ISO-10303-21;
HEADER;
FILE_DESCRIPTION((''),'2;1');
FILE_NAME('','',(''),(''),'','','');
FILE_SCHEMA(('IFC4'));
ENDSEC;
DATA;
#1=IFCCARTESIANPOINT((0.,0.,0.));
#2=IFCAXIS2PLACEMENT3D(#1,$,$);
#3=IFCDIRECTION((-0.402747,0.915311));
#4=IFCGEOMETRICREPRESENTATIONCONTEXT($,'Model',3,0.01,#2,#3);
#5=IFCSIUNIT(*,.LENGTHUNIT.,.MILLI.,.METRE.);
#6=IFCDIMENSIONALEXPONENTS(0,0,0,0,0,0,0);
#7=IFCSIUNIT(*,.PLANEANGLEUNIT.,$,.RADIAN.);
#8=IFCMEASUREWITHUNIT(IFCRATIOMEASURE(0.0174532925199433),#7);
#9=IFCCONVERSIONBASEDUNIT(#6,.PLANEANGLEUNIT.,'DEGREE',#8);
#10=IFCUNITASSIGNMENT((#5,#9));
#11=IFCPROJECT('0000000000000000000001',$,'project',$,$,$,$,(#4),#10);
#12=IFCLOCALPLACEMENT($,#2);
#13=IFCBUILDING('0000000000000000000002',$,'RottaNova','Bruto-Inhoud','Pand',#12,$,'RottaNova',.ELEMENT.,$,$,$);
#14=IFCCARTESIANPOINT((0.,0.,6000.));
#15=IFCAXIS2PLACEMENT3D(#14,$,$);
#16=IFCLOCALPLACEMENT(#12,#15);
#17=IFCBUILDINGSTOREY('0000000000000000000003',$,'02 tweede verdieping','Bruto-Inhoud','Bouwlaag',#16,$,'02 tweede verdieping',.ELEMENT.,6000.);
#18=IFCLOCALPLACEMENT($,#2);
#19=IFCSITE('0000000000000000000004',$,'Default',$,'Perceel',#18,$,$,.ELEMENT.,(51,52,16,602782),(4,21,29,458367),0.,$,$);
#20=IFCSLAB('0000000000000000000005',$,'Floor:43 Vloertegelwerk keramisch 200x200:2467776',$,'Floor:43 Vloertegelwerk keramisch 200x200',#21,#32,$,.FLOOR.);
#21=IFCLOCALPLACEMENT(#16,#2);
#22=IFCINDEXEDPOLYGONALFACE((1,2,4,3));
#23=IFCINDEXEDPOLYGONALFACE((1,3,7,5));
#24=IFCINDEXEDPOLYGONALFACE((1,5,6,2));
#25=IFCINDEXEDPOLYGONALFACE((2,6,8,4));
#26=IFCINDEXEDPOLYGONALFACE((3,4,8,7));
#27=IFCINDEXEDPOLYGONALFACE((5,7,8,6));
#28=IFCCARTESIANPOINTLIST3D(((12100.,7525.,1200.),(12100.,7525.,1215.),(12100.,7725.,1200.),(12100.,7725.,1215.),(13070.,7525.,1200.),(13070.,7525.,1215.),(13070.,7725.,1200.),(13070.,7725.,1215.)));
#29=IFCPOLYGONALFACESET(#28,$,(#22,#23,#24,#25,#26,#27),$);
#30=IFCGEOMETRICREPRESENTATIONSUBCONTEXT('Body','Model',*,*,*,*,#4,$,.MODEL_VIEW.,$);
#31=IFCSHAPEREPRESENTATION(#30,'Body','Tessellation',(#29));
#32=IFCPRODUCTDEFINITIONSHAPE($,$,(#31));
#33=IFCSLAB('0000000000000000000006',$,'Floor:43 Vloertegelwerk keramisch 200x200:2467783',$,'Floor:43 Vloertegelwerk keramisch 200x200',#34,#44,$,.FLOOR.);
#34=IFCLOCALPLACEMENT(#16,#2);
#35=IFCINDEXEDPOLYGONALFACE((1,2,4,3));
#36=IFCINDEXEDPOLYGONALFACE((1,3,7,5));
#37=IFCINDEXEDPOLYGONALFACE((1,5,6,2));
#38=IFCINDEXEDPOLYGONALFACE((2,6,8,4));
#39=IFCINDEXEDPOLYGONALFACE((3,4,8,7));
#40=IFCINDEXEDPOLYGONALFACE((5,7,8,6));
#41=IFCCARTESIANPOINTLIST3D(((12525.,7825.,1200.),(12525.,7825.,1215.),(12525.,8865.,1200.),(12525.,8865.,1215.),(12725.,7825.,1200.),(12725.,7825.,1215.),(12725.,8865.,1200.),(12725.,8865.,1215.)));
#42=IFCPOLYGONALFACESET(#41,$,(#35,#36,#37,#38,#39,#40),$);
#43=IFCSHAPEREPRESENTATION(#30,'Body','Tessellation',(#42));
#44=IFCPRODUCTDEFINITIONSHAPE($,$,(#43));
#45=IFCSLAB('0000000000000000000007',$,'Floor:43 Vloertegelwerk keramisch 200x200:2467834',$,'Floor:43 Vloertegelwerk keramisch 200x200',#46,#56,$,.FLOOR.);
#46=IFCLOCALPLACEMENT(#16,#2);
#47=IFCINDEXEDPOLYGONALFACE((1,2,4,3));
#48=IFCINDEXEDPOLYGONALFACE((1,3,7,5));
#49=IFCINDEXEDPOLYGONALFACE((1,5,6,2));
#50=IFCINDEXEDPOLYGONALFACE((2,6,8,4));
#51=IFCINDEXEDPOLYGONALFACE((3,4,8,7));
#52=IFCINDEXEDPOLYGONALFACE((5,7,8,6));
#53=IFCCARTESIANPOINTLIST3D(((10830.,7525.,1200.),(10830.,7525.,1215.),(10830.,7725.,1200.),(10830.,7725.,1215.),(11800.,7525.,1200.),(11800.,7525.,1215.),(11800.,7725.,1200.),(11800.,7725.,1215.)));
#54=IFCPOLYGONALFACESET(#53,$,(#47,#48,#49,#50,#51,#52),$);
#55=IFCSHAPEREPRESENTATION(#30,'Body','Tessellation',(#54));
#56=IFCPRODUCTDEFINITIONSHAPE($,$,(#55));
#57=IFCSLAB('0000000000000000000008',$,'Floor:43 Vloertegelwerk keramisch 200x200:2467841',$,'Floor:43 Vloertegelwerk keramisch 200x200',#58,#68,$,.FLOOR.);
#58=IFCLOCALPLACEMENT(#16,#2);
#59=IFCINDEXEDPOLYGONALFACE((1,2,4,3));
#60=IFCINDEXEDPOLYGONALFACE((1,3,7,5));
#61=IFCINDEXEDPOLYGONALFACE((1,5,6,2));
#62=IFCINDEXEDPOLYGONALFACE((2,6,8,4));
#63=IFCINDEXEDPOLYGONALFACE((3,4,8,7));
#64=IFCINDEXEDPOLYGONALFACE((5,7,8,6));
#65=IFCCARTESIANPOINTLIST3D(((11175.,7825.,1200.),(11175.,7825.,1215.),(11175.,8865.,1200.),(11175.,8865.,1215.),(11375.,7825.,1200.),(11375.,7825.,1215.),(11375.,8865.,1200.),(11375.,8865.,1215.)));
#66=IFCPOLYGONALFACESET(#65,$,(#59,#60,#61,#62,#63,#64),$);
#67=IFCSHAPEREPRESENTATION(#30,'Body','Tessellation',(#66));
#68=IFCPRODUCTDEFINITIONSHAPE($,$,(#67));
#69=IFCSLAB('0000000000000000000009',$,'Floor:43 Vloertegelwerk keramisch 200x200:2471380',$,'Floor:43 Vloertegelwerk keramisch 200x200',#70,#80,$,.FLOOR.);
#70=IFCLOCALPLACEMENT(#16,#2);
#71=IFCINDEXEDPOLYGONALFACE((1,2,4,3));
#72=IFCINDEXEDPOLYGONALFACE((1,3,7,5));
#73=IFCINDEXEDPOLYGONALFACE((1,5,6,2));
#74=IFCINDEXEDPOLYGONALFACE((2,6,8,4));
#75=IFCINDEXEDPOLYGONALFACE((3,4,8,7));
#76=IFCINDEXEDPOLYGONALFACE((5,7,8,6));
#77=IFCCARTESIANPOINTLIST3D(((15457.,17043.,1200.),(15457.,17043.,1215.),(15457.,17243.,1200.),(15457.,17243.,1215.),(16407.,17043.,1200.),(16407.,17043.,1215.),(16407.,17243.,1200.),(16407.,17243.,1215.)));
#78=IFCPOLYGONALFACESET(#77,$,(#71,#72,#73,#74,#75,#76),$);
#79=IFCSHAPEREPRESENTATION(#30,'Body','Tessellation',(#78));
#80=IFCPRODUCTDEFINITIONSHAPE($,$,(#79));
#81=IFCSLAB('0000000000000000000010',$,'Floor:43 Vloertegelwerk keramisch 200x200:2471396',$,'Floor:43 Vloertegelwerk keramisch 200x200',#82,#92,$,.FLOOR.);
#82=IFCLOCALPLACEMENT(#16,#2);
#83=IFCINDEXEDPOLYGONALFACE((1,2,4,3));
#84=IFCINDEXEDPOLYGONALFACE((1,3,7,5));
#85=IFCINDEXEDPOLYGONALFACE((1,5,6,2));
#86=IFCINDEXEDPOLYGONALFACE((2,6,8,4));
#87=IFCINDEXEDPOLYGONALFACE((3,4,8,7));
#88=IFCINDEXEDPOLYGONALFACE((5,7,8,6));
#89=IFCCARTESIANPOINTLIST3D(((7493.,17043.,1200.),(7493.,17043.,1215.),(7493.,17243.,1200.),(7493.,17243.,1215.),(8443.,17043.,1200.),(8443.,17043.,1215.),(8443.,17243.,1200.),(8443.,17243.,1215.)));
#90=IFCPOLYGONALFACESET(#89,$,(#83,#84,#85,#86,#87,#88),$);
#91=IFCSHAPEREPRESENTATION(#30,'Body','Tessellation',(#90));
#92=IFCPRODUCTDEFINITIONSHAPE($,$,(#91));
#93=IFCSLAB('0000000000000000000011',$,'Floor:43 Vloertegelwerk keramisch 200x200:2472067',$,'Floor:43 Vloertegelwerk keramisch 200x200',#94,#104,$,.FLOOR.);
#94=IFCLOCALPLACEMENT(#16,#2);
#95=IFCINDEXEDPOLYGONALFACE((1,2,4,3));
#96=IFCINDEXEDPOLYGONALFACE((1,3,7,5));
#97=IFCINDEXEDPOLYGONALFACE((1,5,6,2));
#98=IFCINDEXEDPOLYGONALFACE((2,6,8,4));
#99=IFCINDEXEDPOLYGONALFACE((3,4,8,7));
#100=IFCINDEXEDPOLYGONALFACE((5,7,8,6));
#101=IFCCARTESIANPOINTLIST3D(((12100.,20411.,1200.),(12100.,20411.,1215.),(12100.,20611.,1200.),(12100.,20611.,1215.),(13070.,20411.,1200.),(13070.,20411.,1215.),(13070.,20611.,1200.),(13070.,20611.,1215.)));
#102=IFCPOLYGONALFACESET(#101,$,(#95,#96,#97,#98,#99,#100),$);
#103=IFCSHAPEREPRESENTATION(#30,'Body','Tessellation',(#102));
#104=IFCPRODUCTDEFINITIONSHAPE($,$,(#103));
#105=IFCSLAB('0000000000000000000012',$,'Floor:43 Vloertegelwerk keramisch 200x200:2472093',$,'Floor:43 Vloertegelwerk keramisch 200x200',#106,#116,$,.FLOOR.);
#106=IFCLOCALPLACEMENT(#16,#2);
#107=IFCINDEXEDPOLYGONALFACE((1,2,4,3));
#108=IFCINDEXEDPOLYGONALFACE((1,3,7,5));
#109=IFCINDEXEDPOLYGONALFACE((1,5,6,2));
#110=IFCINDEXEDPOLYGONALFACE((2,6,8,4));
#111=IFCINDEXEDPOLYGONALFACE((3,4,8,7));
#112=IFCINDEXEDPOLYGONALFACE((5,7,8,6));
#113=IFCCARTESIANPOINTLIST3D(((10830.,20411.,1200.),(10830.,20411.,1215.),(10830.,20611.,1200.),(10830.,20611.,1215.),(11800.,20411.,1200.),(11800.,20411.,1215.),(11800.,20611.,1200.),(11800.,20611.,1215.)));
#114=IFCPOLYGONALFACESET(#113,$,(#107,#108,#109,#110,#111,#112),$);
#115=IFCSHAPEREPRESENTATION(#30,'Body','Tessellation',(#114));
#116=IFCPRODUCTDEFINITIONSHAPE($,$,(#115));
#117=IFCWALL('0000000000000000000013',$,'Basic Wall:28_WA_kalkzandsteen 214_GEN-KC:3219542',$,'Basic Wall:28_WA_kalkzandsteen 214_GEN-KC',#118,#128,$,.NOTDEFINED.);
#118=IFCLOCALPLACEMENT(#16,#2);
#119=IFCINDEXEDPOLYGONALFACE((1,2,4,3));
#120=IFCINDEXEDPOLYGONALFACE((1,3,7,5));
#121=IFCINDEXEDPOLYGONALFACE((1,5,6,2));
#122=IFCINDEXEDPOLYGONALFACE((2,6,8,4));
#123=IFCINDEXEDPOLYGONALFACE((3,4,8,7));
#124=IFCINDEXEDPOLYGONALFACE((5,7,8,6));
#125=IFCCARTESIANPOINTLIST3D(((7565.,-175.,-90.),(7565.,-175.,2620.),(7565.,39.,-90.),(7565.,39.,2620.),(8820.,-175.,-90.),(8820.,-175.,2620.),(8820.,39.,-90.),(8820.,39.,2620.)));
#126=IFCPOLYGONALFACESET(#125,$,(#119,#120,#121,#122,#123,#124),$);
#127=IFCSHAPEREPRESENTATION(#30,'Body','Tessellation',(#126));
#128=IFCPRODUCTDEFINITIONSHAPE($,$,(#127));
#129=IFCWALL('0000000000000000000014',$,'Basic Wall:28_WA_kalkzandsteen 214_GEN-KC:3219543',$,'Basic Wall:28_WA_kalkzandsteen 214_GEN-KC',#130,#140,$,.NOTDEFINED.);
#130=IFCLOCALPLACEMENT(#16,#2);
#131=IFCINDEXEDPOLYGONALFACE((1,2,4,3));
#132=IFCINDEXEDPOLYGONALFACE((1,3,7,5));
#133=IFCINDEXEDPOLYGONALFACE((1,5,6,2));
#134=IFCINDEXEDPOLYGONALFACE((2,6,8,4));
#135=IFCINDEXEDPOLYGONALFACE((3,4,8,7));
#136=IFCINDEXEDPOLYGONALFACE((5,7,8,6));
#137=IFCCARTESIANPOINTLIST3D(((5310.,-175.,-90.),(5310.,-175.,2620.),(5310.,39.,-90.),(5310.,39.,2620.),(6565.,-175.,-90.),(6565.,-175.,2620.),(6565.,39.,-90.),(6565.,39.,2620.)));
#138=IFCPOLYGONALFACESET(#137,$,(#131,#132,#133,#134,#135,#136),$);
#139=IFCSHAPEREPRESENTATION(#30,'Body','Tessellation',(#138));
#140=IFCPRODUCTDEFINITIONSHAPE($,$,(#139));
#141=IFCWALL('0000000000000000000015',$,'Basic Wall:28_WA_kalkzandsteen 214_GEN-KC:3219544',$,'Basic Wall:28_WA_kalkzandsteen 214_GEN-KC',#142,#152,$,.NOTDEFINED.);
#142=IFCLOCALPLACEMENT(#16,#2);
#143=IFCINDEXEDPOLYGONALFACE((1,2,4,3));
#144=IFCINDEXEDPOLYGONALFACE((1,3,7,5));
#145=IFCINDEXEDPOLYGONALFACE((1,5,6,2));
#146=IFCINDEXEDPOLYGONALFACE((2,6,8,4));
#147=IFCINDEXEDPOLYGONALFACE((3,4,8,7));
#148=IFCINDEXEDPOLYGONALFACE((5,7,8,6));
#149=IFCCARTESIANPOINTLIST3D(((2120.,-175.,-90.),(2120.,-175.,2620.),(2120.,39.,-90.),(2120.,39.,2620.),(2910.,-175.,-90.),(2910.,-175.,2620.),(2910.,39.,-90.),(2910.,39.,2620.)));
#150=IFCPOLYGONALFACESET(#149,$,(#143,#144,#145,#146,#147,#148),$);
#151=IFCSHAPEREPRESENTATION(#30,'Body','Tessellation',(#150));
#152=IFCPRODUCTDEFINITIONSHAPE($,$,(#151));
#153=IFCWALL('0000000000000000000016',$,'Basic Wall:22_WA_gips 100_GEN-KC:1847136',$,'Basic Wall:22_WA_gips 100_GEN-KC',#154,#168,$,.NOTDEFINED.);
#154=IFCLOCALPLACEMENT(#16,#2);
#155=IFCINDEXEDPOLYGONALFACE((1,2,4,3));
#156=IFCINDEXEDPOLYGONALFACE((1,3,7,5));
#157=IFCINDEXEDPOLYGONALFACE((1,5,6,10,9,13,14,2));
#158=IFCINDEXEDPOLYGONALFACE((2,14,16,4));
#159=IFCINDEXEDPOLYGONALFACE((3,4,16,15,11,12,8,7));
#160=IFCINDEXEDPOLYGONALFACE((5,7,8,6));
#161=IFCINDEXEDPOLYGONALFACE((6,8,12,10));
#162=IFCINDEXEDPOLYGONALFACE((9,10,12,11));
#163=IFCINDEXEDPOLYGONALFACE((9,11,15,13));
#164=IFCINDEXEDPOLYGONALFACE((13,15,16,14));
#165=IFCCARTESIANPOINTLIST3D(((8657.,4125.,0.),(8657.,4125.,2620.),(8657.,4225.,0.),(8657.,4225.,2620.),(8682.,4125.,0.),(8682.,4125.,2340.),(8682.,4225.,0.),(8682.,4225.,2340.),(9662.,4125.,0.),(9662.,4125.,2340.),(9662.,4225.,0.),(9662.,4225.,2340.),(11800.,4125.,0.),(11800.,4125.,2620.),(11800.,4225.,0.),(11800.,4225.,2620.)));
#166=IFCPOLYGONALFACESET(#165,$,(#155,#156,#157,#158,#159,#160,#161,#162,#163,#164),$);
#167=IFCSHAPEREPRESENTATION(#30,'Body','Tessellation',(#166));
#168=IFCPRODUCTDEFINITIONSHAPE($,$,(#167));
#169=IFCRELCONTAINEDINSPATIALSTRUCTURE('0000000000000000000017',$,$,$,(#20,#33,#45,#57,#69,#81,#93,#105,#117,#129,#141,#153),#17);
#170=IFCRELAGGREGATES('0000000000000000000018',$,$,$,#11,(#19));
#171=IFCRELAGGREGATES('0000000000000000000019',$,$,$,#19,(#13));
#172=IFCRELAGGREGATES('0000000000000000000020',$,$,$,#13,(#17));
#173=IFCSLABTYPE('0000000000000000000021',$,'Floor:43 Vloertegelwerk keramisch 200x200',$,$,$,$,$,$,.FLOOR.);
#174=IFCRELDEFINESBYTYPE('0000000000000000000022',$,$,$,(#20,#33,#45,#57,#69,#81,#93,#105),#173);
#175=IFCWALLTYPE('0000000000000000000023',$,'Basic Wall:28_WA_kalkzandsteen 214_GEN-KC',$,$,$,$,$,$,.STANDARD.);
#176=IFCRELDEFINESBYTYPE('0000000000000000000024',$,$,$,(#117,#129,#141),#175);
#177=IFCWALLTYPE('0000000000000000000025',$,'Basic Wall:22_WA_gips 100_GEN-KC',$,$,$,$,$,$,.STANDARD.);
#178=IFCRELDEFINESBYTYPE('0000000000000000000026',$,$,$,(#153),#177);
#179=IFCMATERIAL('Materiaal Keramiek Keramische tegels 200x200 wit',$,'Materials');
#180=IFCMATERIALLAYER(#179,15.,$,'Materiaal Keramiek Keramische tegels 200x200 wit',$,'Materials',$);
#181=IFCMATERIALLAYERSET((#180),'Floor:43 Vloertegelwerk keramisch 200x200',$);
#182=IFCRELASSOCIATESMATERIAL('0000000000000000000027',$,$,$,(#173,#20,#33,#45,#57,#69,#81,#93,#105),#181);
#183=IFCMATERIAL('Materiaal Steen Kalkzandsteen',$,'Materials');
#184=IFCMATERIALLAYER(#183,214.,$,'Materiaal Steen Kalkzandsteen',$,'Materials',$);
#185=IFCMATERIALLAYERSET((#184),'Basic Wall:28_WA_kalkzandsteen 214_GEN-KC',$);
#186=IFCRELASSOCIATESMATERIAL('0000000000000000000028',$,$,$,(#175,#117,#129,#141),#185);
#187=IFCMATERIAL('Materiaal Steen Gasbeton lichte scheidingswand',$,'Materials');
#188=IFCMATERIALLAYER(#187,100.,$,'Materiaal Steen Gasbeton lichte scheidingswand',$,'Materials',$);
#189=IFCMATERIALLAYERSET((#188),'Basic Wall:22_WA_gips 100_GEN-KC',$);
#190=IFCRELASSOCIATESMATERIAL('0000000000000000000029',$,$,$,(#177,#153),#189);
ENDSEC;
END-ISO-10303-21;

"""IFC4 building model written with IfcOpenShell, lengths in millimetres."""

from ifc_helpers import new_model, entity, si_unit, converted_unit, direction, frame, frame_2d, origin, origin_2d_with_axis, place, context, subcontext, project, spatial, rectangle, extrude, material, layer, layer_set, layer_usage, type_object, element, save


model = new_model("IFC4")

# Units and contexts
model_context = context("Model", 3, precision=0.01, world=origin(), true_north=direction((-0.402747, 0.915311)))
body_context = subcontext(model_context, "Body", "Model", "MODEL_VIEW")
ifc_project = project(units=[si_unit("LENGTHUNIT", "METRE", prefix="MILLI"), converted_unit("PLANEANGLEUNIT", "DEGREE", entity("IfcRatioMeasure", 0.0174532925199433), si_unit("PLANEANGLEUNIT", "RADIAN"), dimensions=[0, 0, 0, 0, 0, 0, 0])], contexts=[model_context])

# Site, building, storey
site_placement = place(None, origin())
site = spatial("IfcSite", under=ifc_project, at=site_placement, Name="Default", ObjectType="Perceel", CompositionType="ELEMENT", RefLatitude=(51, 52, 16, 602782), RefLongitude=(4, 21, 29, 458367), RefElevation=0.0)
building_placement = place(None, origin())
building = spatial("IfcBuilding", under=site, at=building_placement, Name="RottaNova", Description="Bruto-Inhoud", ObjectType="Pand", LongName="RottaNova", CompositionType="ELEMENT")
storey_placement = place(building_placement, frame((0.0, 0.0, 6000.0)))
storey = spatial("IfcBuildingStorey", under=building, at=storey_placement, Name="02 tweede verdieping", Description="Bruto-Inhoud", ObjectType="Bouwlaag", LongName="02 tweede verdieping", CompositionType="ELEMENT", Elevation=6000.0)

# Slabs
ifc_material_1 = material(Name="Materiaal Keramiek Keramische tegels 200x200 wit", Category="Materials")
ifc_layer_1 = layer(ifc_material_1, 15.0, Name="Materiaal Keramiek Keramische tegels 200x200 wit", Category="Materials")
ifc_layer_set_1 = layer_set([ifc_layer_1], Name="Floor:43 Vloertegelwerk keramisch 200x200")
ifc_layer_usage_1 = layer_usage(ifc_layer_set_1, "AXIS3", "POSITIVE", 0.0)
slab_type_1 = type_object("IfcSlabType", Name="Floor:43 Vloertegelwerk keramisch 200x200", PredefinedType="FLOOR", material=ifc_layer_set_1)
slab_1_placement = place(storey_placement, origin())
element("IfcSlab", 1, at=slab_1_placement, inside=storey, type_object=slab_type_1, material=ifc_layer_usage_1, Name="Floor:43 Vloertegelwerk keramisch 200x200:2467776", ObjectType="Floor:43 Vloertegelwerk keramisch 200x200", PredefinedType="FLOOR", context=body_context, shape_type="SweptSolid", body=[
    extrude(rectangle(XDim=200.0, YDim=970.0, at=origin_2d_with_axis()), frame((12585.0, 7625.0, 1215.0), z_axis=(0.0, 0.0, -1.0), x_axis=(0.0, 1.0, 0.0)), (0.0, 0.0, 1.0), 15.0),
])
slab_2_placement = place(storey_placement, origin())
element("IfcSlab", 2, at=slab_2_placement, inside=storey, type_object=slab_type_1, material=ifc_layer_usage_1, Name="Floor:43 Vloertegelwerk keramisch 200x200:2467783", ObjectType="Floor:43 Vloertegelwerk keramisch 200x200", PredefinedType="FLOOR", context=body_context, shape_type="SweptSolid", body=[
    extrude(rectangle(XDim=1040.0, YDim=200.0, at=origin_2d_with_axis()), frame((12625.0, 8345.0, 1215.0), z_axis=(0.0, 0.0, -1.0), x_axis=(0.0, 1.0, 0.0)), (0.0, 0.0, 1.0), 15.0),
])
slab_3_placement = place(storey_placement, origin())
element("IfcSlab", 3, at=slab_3_placement, inside=storey, type_object=slab_type_1, material=ifc_layer_usage_1, Name="Floor:43 Vloertegelwerk keramisch 200x200:2467834", ObjectType="Floor:43 Vloertegelwerk keramisch 200x200", PredefinedType="FLOOR", context=body_context, shape_type="SweptSolid", body=[
    extrude(rectangle(XDim=200.0, YDim=970.0, at=origin_2d_with_axis()), frame((11315.0, 7625.0, 1215.0), z_axis=(0.0, 0.0, -1.0), x_axis=(0.0, 1.0, 0.0)), (0.0, 0.0, 1.0), 15.0),
])
slab_4_placement = place(storey_placement, origin())
element("IfcSlab", 4, at=slab_4_placement, inside=storey, type_object=slab_type_1, material=ifc_layer_usage_1, Name="Floor:43 Vloertegelwerk keramisch 200x200:2467841", ObjectType="Floor:43 Vloertegelwerk keramisch 200x200", PredefinedType="FLOOR", context=body_context, shape_type="SweptSolid", body=[
    extrude(rectangle(XDim=1040.0, YDim=200.0, at=origin_2d_with_axis()), frame((11275.0, 8345.0, 1215.0), z_axis=(0.0, 0.0, -1.0), x_axis=(0.0, 1.0, 0.0)), (0.0, 0.0, 1.0), 15.0),
])
slab_5_placement = place(storey_placement, origin())
element("IfcSlab", 5, at=slab_5_placement, inside=storey, type_object=slab_type_1, material=ifc_layer_usage_1, Name="Floor:43 Vloertegelwerk keramisch 200x200:2471380", ObjectType="Floor:43 Vloertegelwerk keramisch 200x200", PredefinedType="FLOOR", context=body_context, shape_type="SweptSolid", body=[
    extrude(rectangle(XDim=200.0, YDim=950.0, at=frame_2d((0.0, 0.0), x_axis=(1.0, 0.0))), frame((15932.0, 17143.0, 1215.0), z_axis=(0.0, 0.0, -1.0), x_axis=(0.0, 1.0, 0.0)), (0.0, 0.0, 1.0), 15.0),
])
slab_6_placement = place(storey_placement, origin())
element("IfcSlab", 6, at=slab_6_placement, inside=storey, type_object=slab_type_1, material=ifc_layer_usage_1, Name="Floor:43 Vloertegelwerk keramisch 200x200:2471396", ObjectType="Floor:43 Vloertegelwerk keramisch 200x200", PredefinedType="FLOOR", context=body_context, shape_type="SweptSolid", body=[
    extrude(rectangle(XDim=200.0, YDim=950.0, at=origin_2d_with_axis()), frame((7968.0, 17143.0, 1215.0), z_axis=(0.0, 0.0, -1.0), x_axis=(0.0, 1.0, 0.0)), (0.0, 0.0, 1.0), 15.0),
])
slab_7_placement = place(storey_placement, origin())
element("IfcSlab", 7, at=slab_7_placement, inside=storey, type_object=slab_type_1, material=ifc_layer_usage_1, Name="Floor:43 Vloertegelwerk keramisch 200x200:2472067", ObjectType="Floor:43 Vloertegelwerk keramisch 200x200", PredefinedType="FLOOR", context=body_context, shape_type="SweptSolid", body=[
    extrude(rectangle(XDim=200.0, YDim=970.0, at=origin_2d_with_axis()), frame((12585.0, 20511.0, 1215.0), z_axis=(0.0, 0.0, -1.0), x_axis=(0.0, 1.0, 0.0)), (0.0, 0.0, 1.0), 15.0),
])
slab_8_placement = place(storey_placement, origin())
element("IfcSlab", 8, at=slab_8_placement, inside=storey, type_object=slab_type_1, material=ifc_layer_usage_1, Name="Floor:43 Vloertegelwerk keramisch 200x200:2472093", ObjectType="Floor:43 Vloertegelwerk keramisch 200x200", PredefinedType="FLOOR", context=body_context, shape_type="SweptSolid", body=[
    extrude(rectangle(XDim=200.0, YDim=970.0, at=origin_2d_with_axis()), frame((11315.0, 20511.0, 1215.0), z_axis=(0.0, 0.0, -1.0), x_axis=(0.0, 1.0, 0.0)), (0.0, 0.0, 1.0), 15.0),
])

# Walls
ifc_material_2 = material(Name="Materiaal Steen Kalkzandsteen", Category="Materials")
ifc_layer_2 = layer(ifc_material_2, 214.0, Name="Materiaal Steen Kalkzandsteen", Category="Materials")
ifc_layer_set_2 = layer_set([ifc_layer_2], Name="Basic Wall:28_WA_kalkzandsteen 214_GEN-KC")
wall_type_1 = type_object("IfcWallType", Name="Basic Wall:28_WA_kalkzandsteen 214_GEN-KC", PredefinedType="STANDARD", material=ifc_layer_set_2)
wall_1_placement = place(storey_placement, frame((8820.0, -68.0, -90.0), z_axis=(0.0, 0.0, 1.0), x_axis=(-1.0, 0.0, 0.0)))
element("IfcWall", 9, at=wall_1_placement, inside=storey, type_object=wall_type_1, material=ifc_layer_set_2, Name="Basic Wall:28_WA_kalkzandsteen 214_GEN-KC:3219542", ObjectType="Basic Wall:28_WA_kalkzandsteen 214_GEN-KC", PredefinedType="NOTDEFINED", context=body_context, shape_type="SweptSolid", body=[
    extrude(rectangle(XDim=1255.0, YDim=214.0, at=frame_2d((627.5, 0.0), x_axis=(-1.0, 0.0))), origin(), (0.0, 0.0, 1.0), 2710.0),
])
wall_2_placement = place(storey_placement, frame((6565.0, -68.0, -90.0), z_axis=(0.0, 0.0, 1.0), x_axis=(-1.0, 0.0, 0.0)))
element("IfcWall", 10, at=wall_2_placement, inside=storey, type_object=wall_type_1, material=ifc_layer_set_2, Name="Basic Wall:28_WA_kalkzandsteen 214_GEN-KC:3219543", ObjectType="Basic Wall:28_WA_kalkzandsteen 214_GEN-KC", PredefinedType="NOTDEFINED", context=body_context, shape_type="SweptSolid", body=[
    extrude(rectangle(XDim=1255.0, YDim=214.0, at=frame_2d((627.5, 0.0), x_axis=(-1.0, 0.0))), origin(), (0.0, 0.0, 1.0), 2710.0),
])
wall_3_placement = place(storey_placement, frame((2910.0, -68.0, -90.0), z_axis=(0.0, 0.0, 1.0), x_axis=(-1.0, 0.0, 0.0)))
element("IfcWall", 11, at=wall_3_placement, inside=storey, type_object=wall_type_1, material=ifc_layer_set_2, Name="Basic Wall:28_WA_kalkzandsteen 214_GEN-KC:3219544", ObjectType="Basic Wall:28_WA_kalkzandsteen 214_GEN-KC", PredefinedType="NOTDEFINED", context=body_context, shape_type="SweptSolid", body=[
    extrude(rectangle(XDim=790.0, YDim=214.0, at=frame_2d((395.0, 0.0), x_axis=(-1.0, 0.0))), origin(), (0.0, 0.0, 1.0), 2710.0),
])

# Wall, opening
ifc_material_3 = material(Name="Materiaal Steen Gasbeton lichte scheidingswand", Category="Materials")
ifc_layer_3 = layer(ifc_material_3, 100.0, Name="Materiaal Steen Gasbeton lichte scheidingswand", Category="Materials")
ifc_layer_set_3 = layer_set([ifc_layer_3], Name="Basic Wall:22_WA_gips 100_GEN-KC")
wall_type_2 = type_object("IfcWallType", Name="Basic Wall:22_WA_gips 100_GEN-KC", PredefinedType="STANDARD", material=ifc_layer_set_3)
wall_4_placement = place(storey_placement, frame((8657.0, 4175.0, 0.0)))
wall_4 = element("IfcWall", 12, at=wall_4_placement, inside=storey, type_object=wall_type_2, material=ifc_layer_set_3, Name="Basic Wall:22_WA_gips 100_GEN-KC:1847136", ObjectType="Basic Wall:22_WA_gips 100_GEN-KC", PredefinedType="NOTDEFINED", context=body_context, shape_type="SweptSolid", body=[
    extrude(rectangle(XDim=3143.0, YDim=100.0, at=frame_2d((1571.5, 0.0), x_axis=(-1.0, 0.0))), origin(), (0.0, 0.0, 1.0), 2620.0),
])
opening_1_placement = place(wall_4_placement, frame((1005.0, 50.0, -90.0)))
element("IfcOpeningElement", 13, at=opening_1_placement, cuts=wall_4, PredefinedType="OPENING", context=body_context, shape_type="SweptSolid", body=[
    extrude(rectangle(XDim=2430.0, YDim=980.0, at=frame_2d((1215.0, 490.0), x_axis=(1.0, 0.0))), frame((0.0, 0.0, 0.0), z_axis=(0.0, -1.0, 0.0), x_axis=(0.0, 0.0, 1.0)), (0.0, 0.0, 1.0), 100.0),
])

save(model, "model.ifc")
